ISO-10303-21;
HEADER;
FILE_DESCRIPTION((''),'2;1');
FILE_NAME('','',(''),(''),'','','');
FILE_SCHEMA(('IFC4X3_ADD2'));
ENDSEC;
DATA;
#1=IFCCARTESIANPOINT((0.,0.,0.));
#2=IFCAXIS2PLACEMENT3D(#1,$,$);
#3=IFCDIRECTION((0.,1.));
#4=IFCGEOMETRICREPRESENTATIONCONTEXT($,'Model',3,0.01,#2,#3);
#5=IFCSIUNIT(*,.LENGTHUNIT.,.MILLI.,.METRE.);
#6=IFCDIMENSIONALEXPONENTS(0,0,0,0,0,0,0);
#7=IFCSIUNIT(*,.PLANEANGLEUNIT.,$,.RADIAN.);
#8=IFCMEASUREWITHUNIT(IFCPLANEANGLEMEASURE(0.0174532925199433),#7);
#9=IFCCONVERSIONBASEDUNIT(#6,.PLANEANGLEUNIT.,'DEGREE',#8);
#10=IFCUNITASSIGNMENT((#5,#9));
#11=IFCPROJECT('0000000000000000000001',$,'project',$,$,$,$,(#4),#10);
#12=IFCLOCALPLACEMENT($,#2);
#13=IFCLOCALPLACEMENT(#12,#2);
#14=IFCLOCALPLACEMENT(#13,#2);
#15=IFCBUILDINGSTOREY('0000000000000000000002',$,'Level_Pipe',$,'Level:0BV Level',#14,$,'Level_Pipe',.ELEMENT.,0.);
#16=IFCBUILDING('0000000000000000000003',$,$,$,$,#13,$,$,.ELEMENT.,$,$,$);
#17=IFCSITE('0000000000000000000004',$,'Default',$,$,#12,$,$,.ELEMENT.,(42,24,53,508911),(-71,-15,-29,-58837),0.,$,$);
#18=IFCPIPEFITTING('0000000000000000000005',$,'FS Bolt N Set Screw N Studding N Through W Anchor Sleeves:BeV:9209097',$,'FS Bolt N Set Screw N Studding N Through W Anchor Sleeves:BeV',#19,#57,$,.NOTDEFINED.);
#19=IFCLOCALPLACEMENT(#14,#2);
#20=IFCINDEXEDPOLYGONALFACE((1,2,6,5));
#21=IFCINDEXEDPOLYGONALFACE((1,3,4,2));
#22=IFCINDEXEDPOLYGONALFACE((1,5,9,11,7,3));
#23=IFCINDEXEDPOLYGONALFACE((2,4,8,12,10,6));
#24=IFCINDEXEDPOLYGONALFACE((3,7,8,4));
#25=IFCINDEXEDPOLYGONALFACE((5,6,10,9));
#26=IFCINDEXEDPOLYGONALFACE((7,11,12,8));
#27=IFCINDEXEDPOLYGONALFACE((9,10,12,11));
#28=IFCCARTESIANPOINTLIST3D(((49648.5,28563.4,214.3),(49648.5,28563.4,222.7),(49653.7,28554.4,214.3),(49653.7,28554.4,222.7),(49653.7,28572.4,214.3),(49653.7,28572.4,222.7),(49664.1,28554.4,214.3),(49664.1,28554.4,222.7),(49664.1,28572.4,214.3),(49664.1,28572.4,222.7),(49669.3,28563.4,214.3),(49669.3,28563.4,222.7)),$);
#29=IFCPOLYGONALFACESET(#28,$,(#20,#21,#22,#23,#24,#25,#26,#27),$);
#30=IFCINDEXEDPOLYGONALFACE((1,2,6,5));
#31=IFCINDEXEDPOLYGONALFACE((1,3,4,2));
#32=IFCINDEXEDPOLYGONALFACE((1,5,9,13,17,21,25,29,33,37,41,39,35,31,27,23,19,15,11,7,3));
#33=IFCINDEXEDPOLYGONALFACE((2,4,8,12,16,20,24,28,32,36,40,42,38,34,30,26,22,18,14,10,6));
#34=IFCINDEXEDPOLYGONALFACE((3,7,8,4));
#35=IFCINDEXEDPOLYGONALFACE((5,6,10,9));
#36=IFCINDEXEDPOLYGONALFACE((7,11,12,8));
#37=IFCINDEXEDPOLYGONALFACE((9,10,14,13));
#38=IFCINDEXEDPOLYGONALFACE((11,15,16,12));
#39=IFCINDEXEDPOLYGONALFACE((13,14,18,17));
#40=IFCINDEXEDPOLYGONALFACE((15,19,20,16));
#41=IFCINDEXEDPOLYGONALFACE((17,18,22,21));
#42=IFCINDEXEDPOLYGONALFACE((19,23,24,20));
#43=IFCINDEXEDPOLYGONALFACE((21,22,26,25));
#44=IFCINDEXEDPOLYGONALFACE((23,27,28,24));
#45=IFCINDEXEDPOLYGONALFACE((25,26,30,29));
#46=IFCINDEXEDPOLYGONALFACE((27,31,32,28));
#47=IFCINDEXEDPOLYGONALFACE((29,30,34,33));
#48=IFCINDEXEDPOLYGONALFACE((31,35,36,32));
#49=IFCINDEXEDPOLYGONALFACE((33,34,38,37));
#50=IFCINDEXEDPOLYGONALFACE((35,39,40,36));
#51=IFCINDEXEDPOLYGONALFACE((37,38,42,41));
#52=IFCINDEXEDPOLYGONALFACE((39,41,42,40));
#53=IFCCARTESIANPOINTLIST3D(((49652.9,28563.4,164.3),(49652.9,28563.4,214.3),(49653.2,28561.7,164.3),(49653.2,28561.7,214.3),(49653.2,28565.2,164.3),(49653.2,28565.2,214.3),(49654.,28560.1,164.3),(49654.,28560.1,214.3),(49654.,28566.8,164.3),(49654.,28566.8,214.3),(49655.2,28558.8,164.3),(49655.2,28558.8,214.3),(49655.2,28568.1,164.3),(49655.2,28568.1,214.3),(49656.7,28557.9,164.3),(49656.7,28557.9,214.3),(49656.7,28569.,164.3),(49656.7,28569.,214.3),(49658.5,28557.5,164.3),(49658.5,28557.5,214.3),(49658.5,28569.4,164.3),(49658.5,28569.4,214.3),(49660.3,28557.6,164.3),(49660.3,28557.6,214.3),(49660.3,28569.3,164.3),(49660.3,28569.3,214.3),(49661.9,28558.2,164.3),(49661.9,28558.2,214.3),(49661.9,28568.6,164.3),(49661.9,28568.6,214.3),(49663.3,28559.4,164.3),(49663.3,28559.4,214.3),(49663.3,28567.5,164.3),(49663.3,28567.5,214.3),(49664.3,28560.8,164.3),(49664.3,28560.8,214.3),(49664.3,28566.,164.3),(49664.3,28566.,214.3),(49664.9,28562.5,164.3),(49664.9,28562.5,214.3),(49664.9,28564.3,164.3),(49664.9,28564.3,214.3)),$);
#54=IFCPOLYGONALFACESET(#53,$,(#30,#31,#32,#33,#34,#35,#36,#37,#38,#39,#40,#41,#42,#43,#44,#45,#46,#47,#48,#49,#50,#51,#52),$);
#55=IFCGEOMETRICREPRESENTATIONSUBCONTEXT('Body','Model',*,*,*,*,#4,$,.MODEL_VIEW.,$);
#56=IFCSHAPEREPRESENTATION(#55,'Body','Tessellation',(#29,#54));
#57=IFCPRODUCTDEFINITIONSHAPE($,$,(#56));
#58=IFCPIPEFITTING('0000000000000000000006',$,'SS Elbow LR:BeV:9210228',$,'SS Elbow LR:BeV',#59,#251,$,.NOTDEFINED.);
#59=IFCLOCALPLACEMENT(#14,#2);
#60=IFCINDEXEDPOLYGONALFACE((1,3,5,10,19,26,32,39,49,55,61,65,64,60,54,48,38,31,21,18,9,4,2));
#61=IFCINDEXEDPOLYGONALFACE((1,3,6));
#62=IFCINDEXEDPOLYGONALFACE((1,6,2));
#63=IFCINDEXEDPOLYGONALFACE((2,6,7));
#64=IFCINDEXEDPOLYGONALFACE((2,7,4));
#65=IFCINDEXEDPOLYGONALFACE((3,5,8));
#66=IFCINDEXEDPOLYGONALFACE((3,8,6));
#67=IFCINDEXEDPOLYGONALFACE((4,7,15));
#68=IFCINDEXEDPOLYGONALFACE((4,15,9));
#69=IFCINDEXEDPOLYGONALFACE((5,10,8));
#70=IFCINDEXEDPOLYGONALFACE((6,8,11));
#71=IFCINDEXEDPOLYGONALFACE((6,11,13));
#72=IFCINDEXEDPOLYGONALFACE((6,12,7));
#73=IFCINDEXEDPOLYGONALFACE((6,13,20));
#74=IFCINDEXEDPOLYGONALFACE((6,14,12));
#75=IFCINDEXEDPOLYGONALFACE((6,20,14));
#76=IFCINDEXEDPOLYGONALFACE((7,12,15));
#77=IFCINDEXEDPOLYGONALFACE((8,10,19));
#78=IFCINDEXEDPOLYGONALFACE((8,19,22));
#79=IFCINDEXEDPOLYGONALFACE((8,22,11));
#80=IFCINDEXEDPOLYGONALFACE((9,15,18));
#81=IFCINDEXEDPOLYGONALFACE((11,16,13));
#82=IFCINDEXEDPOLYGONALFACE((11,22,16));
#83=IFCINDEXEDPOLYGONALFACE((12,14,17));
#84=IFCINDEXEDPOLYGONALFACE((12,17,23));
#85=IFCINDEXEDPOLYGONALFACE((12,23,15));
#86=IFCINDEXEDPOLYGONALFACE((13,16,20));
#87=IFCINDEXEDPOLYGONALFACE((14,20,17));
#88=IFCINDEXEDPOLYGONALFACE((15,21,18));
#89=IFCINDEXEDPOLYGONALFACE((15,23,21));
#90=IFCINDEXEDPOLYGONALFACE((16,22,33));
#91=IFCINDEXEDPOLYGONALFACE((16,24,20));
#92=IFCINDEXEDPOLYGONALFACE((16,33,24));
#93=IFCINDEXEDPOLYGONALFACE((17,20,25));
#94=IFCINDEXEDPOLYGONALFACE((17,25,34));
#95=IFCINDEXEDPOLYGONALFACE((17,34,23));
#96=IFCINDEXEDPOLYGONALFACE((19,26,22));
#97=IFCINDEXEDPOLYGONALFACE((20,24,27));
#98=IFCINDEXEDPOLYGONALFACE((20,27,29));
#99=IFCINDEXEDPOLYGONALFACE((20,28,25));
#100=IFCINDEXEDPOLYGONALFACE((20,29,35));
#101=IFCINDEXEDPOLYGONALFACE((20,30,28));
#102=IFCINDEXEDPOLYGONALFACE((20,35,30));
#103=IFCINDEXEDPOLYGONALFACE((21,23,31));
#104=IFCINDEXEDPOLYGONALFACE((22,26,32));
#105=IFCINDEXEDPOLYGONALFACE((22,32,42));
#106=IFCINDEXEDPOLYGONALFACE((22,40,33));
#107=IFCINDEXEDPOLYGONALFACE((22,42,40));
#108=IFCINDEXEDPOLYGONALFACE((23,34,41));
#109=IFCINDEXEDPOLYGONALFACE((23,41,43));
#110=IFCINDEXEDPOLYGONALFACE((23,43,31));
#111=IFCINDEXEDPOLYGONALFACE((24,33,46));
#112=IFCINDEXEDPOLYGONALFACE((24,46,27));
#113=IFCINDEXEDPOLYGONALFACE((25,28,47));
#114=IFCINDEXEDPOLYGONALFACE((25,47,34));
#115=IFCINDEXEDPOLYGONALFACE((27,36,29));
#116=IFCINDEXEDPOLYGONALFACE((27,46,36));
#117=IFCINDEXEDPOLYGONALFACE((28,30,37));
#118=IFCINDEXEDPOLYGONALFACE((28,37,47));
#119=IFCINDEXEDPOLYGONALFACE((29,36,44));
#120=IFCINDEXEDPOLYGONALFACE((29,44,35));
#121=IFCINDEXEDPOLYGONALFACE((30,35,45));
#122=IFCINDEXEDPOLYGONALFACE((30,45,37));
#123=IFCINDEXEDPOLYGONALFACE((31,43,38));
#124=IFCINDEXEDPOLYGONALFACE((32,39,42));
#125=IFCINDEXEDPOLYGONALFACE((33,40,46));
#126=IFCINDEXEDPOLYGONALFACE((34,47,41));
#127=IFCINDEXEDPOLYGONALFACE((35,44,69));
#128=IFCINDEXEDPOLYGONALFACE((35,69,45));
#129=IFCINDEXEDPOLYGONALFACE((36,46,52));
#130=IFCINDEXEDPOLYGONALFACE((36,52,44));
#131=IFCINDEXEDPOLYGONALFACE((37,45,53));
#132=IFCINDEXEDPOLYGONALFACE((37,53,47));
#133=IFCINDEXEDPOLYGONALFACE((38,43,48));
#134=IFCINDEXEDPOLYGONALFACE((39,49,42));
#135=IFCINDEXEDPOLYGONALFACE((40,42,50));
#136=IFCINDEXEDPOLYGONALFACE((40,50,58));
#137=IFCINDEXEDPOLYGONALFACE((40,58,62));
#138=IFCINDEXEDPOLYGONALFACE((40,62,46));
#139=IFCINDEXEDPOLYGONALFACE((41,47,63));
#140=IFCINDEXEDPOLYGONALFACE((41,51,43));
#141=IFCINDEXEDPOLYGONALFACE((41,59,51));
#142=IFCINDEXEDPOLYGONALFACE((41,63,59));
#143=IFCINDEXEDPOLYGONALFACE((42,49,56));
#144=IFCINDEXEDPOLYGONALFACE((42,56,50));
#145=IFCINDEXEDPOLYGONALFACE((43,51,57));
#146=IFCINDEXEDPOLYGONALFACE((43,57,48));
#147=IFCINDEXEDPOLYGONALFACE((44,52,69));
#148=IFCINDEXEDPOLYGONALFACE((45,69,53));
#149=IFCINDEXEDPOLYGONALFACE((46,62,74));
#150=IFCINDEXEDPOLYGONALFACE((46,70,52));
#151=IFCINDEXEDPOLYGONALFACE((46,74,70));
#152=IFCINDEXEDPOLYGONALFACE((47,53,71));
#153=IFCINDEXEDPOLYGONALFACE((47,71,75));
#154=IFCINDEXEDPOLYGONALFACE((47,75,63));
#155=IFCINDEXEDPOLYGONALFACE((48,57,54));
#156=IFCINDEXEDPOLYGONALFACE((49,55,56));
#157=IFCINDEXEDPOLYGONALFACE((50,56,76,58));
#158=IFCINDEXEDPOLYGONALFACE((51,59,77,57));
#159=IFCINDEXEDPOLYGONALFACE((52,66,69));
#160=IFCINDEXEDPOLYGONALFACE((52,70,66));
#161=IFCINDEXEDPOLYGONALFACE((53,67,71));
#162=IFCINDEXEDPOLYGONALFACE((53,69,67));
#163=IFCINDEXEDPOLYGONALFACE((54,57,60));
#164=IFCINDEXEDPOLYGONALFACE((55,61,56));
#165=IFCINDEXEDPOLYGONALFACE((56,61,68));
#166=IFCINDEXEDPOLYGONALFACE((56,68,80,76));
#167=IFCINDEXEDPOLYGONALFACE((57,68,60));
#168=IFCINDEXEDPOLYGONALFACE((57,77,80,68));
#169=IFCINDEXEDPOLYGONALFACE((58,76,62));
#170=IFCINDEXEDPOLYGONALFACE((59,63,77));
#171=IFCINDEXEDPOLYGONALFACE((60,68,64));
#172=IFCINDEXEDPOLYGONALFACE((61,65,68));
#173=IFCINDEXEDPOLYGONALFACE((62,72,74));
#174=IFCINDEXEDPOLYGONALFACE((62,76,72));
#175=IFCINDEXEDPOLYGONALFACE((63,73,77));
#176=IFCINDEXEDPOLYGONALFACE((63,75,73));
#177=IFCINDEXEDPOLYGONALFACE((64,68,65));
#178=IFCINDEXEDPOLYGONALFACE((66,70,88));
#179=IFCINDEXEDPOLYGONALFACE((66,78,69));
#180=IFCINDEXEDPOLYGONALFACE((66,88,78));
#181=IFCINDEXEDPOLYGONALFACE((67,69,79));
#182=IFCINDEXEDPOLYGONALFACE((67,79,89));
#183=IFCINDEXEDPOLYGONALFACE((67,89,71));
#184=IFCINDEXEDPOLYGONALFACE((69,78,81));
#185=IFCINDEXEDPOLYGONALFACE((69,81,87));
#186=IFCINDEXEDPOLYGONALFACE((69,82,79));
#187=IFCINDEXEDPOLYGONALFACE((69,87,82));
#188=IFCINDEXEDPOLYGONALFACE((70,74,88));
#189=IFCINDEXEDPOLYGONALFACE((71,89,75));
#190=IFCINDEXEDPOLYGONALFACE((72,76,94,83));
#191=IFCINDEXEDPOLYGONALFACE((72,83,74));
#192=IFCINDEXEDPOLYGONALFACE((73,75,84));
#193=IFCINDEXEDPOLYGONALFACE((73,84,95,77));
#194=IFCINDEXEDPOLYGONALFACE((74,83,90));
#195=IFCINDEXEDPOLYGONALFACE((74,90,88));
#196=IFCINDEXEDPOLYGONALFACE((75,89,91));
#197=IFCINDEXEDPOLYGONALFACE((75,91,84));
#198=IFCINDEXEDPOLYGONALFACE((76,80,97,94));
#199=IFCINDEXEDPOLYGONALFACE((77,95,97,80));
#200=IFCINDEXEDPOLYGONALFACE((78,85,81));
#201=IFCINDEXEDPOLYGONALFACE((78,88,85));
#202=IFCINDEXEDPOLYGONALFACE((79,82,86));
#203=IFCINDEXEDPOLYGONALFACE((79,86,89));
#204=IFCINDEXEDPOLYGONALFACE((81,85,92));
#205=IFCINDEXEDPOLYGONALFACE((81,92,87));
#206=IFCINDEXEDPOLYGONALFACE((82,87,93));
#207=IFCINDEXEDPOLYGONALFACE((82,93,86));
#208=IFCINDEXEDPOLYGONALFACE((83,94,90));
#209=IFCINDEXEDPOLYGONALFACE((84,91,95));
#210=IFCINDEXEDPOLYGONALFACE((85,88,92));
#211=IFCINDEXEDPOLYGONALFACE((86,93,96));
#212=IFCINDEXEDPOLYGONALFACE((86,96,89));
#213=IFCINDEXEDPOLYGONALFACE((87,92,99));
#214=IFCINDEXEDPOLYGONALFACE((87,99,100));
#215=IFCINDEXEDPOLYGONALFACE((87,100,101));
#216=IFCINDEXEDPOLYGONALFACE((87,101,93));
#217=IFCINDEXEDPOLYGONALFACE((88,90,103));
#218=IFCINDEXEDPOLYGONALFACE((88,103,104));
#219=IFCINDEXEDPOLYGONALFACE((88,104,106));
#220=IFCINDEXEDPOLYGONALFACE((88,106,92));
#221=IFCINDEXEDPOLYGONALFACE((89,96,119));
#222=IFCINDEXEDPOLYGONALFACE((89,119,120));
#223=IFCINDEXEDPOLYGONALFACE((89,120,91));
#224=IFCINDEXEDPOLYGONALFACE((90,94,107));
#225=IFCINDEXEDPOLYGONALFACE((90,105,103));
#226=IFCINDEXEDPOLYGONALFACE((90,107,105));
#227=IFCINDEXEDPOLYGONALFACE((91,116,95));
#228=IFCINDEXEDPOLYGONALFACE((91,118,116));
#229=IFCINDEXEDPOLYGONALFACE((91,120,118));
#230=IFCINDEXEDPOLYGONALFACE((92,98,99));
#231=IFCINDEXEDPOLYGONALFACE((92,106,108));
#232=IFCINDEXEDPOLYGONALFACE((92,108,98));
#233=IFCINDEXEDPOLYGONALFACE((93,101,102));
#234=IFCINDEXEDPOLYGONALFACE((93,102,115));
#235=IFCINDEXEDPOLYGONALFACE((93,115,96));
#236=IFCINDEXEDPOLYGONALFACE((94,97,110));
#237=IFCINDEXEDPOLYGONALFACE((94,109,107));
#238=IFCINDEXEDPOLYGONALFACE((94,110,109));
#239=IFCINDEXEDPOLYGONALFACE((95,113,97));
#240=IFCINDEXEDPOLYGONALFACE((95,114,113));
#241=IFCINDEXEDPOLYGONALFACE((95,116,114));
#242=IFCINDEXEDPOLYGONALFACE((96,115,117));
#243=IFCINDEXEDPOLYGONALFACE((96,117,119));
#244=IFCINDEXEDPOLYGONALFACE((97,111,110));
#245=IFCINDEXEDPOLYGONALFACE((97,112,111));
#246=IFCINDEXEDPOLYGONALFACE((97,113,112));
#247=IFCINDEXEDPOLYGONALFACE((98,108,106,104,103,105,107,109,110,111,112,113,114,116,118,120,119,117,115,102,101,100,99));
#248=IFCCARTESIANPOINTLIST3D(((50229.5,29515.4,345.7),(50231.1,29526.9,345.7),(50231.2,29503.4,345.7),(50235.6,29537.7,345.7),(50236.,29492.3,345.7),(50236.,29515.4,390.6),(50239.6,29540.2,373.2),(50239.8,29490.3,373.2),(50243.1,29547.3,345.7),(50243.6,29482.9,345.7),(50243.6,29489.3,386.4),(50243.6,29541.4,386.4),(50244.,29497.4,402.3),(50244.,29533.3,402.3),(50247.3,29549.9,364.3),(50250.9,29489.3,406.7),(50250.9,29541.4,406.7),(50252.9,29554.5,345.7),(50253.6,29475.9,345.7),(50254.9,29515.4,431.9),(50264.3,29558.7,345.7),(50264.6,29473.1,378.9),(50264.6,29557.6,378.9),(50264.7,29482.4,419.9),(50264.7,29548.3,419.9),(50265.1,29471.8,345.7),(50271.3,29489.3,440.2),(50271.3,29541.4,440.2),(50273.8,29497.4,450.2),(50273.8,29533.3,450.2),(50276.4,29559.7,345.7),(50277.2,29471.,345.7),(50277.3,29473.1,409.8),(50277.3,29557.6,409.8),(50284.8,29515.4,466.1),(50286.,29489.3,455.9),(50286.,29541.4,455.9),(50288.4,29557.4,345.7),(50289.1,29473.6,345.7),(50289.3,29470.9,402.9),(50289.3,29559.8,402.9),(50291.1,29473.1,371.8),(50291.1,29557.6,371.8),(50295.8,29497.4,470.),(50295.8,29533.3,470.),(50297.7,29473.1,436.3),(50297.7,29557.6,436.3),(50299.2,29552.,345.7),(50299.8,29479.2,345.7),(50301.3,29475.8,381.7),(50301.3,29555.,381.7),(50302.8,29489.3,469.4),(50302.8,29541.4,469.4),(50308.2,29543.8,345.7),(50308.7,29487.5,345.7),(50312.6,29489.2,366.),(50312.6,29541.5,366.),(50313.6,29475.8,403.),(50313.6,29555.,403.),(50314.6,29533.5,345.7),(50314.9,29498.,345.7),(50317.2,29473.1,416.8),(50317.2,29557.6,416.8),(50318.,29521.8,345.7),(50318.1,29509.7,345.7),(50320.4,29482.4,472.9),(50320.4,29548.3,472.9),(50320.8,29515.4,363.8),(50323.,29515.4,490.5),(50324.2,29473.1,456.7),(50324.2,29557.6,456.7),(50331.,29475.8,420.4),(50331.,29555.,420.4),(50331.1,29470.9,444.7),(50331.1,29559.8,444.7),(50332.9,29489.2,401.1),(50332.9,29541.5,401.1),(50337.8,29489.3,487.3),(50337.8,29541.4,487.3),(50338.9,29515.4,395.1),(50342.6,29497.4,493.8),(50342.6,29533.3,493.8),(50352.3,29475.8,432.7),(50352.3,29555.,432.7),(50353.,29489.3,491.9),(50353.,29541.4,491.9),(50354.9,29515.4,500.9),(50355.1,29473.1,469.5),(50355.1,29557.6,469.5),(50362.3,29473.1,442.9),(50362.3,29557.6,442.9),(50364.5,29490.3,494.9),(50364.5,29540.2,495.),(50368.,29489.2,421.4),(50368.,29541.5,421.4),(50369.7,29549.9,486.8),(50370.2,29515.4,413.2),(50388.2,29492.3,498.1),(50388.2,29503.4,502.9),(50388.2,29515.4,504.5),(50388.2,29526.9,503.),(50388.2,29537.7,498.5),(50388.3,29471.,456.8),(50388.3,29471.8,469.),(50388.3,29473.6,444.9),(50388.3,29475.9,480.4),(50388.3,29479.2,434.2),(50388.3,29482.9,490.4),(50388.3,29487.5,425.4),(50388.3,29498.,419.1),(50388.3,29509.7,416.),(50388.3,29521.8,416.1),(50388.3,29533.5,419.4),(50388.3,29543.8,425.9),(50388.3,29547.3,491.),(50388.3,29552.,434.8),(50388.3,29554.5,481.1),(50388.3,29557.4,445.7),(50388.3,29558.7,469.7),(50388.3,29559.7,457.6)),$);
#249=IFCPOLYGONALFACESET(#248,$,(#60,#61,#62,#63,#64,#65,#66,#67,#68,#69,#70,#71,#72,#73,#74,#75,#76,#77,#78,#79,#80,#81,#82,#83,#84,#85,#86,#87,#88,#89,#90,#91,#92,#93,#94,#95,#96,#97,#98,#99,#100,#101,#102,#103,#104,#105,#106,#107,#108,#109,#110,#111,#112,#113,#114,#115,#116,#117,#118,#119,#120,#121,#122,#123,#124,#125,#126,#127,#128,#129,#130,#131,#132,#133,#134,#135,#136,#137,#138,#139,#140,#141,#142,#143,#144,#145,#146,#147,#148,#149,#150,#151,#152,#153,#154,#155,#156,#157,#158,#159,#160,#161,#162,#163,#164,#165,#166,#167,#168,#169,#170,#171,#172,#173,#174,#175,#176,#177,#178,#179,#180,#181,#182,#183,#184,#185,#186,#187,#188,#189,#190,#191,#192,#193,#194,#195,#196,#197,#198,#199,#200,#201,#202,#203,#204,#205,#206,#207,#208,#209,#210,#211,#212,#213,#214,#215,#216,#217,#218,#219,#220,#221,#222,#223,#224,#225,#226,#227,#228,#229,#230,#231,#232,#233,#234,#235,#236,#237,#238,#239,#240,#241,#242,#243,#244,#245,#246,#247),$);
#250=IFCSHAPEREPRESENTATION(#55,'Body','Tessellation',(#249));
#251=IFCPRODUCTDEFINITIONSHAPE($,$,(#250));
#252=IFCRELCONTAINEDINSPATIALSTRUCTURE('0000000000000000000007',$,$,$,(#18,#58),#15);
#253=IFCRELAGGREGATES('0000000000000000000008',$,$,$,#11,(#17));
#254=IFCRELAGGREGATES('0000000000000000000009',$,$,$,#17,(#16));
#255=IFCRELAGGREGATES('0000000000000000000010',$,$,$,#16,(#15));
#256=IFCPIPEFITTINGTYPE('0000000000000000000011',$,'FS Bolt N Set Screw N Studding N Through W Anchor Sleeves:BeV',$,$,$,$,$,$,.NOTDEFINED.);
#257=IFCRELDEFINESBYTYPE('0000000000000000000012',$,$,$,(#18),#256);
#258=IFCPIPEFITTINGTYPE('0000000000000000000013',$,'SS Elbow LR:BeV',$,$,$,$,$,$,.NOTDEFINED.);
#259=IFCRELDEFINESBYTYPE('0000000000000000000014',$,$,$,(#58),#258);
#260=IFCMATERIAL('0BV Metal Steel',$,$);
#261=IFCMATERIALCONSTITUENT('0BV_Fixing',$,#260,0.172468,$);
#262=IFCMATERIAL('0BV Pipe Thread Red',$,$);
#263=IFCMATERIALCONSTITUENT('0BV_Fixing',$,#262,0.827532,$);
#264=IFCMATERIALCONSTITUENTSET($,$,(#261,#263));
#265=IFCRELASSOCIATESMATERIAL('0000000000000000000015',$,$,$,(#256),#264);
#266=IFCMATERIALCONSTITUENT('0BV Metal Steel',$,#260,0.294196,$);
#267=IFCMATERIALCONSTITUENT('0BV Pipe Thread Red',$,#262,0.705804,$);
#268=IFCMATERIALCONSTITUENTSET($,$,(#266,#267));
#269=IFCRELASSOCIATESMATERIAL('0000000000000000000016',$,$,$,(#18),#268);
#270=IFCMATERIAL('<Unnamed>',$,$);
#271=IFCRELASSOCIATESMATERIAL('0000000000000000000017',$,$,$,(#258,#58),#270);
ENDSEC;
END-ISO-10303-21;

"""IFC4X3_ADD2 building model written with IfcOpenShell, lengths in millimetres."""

from ifc_helpers import new_model, entity, si_unit, converted_unit, direction, frame, frame_2d, origin, place, context, subcontext, project, spatial, polyline, circle, outline, extrude, source, transform, mapped, material, constituent, constituent_set, type_object, type_shapes, element, save


model = new_model("IFC4X3_ADD2")

# Units and contexts
model_context = context("Model", 3, precision=0.01, world=origin(), true_north=direction((0.0, 1.0)))
body_context = subcontext(model_context, "Body", "Model", "MODEL_VIEW")
ifc_project = project(units=[si_unit("LENGTHUNIT", "METRE", prefix="MILLI"), converted_unit("PLANEANGLEUNIT", "DEGREE", entity("IfcPlaneAngleMeasure", 0.0174532925199433), si_unit("PLANEANGLEUNIT", "RADIAN"), dimensions=[0, 0, 0, 0, 0, 0, 0])], contexts=[model_context])

# Site, building, storey
site_placement = place(None, origin())
site = spatial("IfcSite", under=ifc_project, at=site_placement, Name="Default", CompositionType="ELEMENT", RefLatitude=(42, 24, 53, 508911), RefLongitude=(-71, -15, -29, -58837), RefElevation=0.0)
building_placement = place(site_placement, origin())
building = spatial("IfcBuilding", under=site, at=building_placement, CompositionType="ELEMENT")
storey_placement = place(building_placement, origin())
storey = spatial("IfcBuildingStorey", under=building, at=storey_placement, Name="Level_Pipe", ObjectType="Level:0BV Level", LongName="Level_Pipe", CompositionType="ELEMENT", Elevation=0.0)

# Pipe fitting
ifc_material_1 = material(Name="0BV Metal Steel")
ifc_material_2 = material(Name="0BV Pipe Thread Red")
ifc_material_3 = material(Name="<Unnamed>")
ifc_constituent_1 = constituent(ifc_material_1, Name="0BV_Fixing", fraction=0.172468)
ifc_constituent_2 = constituent(ifc_material_2, Name="0BV_Fixing", fraction=0.827532)
ifc_constituent_set_1 = constituent_set(constituents=[ifc_constituent_1, ifc_constituent_2])
pipe_fitting_type_1 = type_object("IfcPipeFittingType", Name="FS Bolt N Set Screw N Studding N Through W Anchor Sleeves:BeV", PredefinedType="NOTDEFINED", material=ifc_constituent_set_1)
shared_shape_1 = source(origin(), body_context, "Body", "SweptSolid", [
    extrude(outline(polyline([(-5.2, -9.0), (5.2, -9.0), (10.4, 0.0), (5.2, 9.0), (-5.2, 9.0), (-10.4, 0.0), (-5.2, -9.0)])), frame((-8.4, 0.0, 0.0), z_axis=(1.0, 0.0, 0.0), x_axis=(0.0, -1.0, 0.0)), (0.0, 0.0, 1.0), 8.4),
    extrude(circle(Radius=6.0, at=frame_2d((0.0, 0.0), x_axis=(1.0, 0.0))), frame((0.0, 0.0, 0.0), z_axis=(1.0, 0.0, 0.0), x_axis=(0.0, -1.0, 0.0)), (0.0, 0.0, 1.0), 50.0),
])
type_shapes(pipe_fitting_type_1, [shared_shape_1])
ifc_constituent_3 = constituent(ifc_material_1, Name="0BV Metal Steel", fraction=0.294196)
ifc_constituent_4 = constituent(ifc_material_2, Name="0BV Pipe Thread Red", fraction=0.705804)
ifc_constituent_set_2 = constituent_set(constituents=[ifc_constituent_3, ifc_constituent_4])
pipe_fitting_1_placement = place(storey_placement, frame((49658.9, 28563.4, 214.3), z_axis=(0.0, -1.0, 0.0), x_axis=(0.0, 0.0, -1.0)))
element("IfcPipeFitting", 1, at=pipe_fitting_1_placement, inside=storey, type_object=pipe_fitting_type_1, material=ifc_constituent_set_2, Name="FS Bolt N Set Screw N Studding N Through W Anchor Sleeves:BeV:9209097", ObjectType="FS Bolt N Set Screw N Studding N Through W Anchor Sleeves:BeV", PredefinedType="NOTDEFINED", context=body_context, shape_type="MappedRepresentation", body=[
    mapped(shared_shape_1, transform((0.0, 0.0, 0.0), scale=1.0)),
])

# Pipe fitting
pipe_fitting_type_2 = type_object("IfcPipeFittingType", Name="SS Elbow LR:BeV", PredefinedType="NOTDEFINED", material=ifc_material_3)
trimmed_curve_1 = entity("IfcTrimmedCurve", entity("IfcCircle", entity("IfcAxis2Placement2D", entity("IfcCartesianPoint", [-69.8, 0.0]), entity("IfcDirection", [0.0, 1.0])), 69.8), [entity("IfcParameterValue", 270.0)], [entity("IfcParameterValue", 0.0)], True, "PARAMETER")
shared_shape_2 = source(origin(), body_context, "Body", "AdvancedSweptSolid", [
    entity("IfcSurfaceCurveSweptAreaSolid", entity("IfcCircleProfileDef", "AREA", None, entity("IfcAxis2Placement2D", entity("IfcCartesianPoint", [44.5, 0.0]), entity("IfcDirection", [1.0, 0.0])), 44.5), entity("IfcAxis2Placement3D", entity("IfcCartesianPoint", [-44.5, 114.3, 0.0]), entity("IfcDirection", [0.0, 0.0, -1.0]), entity("IfcDirection", [1.0, 0.0, 0.0])), trimmed_curve_1, entity("IfcParameterValue", 0.0), entity("IfcParameterValue", 90.0), entity("IfcSurfaceOfLinearExtrusion", entity("IfcArbitraryOpenProfileDef", "CURVE", None, trimmed_curve_1), entity("IfcAxis2Placement3D", entity("IfcCartesianPoint", [0.0, 0.0, -304.8])), entity("IfcDirection", [0.0, 0.0, 1.0]), 1.0)),
])
type_shapes(pipe_fitting_type_2, [shared_shape_2])
pipe_fitting_2_placement = place(storey_placement, frame((50274.0, 29515.4, 460.0), z_axis=(0.0, -1.0, 0.0), x_axis=(-1.0, 0.0, 0.0)))
element("IfcPipeFitting", 2, at=pipe_fitting_2_placement, inside=storey, type_object=pipe_fitting_type_2, material=ifc_material_3, Name="SS Elbow LR:BeV:9210228", ObjectType="SS Elbow LR:BeV", PredefinedType="NOTDEFINED", context=body_context, shape_type="MappedRepresentation", body=[
    mapped(shared_shape_2, transform((0.0, 0.0, 0.0), scale=1.0)),
])

save(model, "model.ifc")
